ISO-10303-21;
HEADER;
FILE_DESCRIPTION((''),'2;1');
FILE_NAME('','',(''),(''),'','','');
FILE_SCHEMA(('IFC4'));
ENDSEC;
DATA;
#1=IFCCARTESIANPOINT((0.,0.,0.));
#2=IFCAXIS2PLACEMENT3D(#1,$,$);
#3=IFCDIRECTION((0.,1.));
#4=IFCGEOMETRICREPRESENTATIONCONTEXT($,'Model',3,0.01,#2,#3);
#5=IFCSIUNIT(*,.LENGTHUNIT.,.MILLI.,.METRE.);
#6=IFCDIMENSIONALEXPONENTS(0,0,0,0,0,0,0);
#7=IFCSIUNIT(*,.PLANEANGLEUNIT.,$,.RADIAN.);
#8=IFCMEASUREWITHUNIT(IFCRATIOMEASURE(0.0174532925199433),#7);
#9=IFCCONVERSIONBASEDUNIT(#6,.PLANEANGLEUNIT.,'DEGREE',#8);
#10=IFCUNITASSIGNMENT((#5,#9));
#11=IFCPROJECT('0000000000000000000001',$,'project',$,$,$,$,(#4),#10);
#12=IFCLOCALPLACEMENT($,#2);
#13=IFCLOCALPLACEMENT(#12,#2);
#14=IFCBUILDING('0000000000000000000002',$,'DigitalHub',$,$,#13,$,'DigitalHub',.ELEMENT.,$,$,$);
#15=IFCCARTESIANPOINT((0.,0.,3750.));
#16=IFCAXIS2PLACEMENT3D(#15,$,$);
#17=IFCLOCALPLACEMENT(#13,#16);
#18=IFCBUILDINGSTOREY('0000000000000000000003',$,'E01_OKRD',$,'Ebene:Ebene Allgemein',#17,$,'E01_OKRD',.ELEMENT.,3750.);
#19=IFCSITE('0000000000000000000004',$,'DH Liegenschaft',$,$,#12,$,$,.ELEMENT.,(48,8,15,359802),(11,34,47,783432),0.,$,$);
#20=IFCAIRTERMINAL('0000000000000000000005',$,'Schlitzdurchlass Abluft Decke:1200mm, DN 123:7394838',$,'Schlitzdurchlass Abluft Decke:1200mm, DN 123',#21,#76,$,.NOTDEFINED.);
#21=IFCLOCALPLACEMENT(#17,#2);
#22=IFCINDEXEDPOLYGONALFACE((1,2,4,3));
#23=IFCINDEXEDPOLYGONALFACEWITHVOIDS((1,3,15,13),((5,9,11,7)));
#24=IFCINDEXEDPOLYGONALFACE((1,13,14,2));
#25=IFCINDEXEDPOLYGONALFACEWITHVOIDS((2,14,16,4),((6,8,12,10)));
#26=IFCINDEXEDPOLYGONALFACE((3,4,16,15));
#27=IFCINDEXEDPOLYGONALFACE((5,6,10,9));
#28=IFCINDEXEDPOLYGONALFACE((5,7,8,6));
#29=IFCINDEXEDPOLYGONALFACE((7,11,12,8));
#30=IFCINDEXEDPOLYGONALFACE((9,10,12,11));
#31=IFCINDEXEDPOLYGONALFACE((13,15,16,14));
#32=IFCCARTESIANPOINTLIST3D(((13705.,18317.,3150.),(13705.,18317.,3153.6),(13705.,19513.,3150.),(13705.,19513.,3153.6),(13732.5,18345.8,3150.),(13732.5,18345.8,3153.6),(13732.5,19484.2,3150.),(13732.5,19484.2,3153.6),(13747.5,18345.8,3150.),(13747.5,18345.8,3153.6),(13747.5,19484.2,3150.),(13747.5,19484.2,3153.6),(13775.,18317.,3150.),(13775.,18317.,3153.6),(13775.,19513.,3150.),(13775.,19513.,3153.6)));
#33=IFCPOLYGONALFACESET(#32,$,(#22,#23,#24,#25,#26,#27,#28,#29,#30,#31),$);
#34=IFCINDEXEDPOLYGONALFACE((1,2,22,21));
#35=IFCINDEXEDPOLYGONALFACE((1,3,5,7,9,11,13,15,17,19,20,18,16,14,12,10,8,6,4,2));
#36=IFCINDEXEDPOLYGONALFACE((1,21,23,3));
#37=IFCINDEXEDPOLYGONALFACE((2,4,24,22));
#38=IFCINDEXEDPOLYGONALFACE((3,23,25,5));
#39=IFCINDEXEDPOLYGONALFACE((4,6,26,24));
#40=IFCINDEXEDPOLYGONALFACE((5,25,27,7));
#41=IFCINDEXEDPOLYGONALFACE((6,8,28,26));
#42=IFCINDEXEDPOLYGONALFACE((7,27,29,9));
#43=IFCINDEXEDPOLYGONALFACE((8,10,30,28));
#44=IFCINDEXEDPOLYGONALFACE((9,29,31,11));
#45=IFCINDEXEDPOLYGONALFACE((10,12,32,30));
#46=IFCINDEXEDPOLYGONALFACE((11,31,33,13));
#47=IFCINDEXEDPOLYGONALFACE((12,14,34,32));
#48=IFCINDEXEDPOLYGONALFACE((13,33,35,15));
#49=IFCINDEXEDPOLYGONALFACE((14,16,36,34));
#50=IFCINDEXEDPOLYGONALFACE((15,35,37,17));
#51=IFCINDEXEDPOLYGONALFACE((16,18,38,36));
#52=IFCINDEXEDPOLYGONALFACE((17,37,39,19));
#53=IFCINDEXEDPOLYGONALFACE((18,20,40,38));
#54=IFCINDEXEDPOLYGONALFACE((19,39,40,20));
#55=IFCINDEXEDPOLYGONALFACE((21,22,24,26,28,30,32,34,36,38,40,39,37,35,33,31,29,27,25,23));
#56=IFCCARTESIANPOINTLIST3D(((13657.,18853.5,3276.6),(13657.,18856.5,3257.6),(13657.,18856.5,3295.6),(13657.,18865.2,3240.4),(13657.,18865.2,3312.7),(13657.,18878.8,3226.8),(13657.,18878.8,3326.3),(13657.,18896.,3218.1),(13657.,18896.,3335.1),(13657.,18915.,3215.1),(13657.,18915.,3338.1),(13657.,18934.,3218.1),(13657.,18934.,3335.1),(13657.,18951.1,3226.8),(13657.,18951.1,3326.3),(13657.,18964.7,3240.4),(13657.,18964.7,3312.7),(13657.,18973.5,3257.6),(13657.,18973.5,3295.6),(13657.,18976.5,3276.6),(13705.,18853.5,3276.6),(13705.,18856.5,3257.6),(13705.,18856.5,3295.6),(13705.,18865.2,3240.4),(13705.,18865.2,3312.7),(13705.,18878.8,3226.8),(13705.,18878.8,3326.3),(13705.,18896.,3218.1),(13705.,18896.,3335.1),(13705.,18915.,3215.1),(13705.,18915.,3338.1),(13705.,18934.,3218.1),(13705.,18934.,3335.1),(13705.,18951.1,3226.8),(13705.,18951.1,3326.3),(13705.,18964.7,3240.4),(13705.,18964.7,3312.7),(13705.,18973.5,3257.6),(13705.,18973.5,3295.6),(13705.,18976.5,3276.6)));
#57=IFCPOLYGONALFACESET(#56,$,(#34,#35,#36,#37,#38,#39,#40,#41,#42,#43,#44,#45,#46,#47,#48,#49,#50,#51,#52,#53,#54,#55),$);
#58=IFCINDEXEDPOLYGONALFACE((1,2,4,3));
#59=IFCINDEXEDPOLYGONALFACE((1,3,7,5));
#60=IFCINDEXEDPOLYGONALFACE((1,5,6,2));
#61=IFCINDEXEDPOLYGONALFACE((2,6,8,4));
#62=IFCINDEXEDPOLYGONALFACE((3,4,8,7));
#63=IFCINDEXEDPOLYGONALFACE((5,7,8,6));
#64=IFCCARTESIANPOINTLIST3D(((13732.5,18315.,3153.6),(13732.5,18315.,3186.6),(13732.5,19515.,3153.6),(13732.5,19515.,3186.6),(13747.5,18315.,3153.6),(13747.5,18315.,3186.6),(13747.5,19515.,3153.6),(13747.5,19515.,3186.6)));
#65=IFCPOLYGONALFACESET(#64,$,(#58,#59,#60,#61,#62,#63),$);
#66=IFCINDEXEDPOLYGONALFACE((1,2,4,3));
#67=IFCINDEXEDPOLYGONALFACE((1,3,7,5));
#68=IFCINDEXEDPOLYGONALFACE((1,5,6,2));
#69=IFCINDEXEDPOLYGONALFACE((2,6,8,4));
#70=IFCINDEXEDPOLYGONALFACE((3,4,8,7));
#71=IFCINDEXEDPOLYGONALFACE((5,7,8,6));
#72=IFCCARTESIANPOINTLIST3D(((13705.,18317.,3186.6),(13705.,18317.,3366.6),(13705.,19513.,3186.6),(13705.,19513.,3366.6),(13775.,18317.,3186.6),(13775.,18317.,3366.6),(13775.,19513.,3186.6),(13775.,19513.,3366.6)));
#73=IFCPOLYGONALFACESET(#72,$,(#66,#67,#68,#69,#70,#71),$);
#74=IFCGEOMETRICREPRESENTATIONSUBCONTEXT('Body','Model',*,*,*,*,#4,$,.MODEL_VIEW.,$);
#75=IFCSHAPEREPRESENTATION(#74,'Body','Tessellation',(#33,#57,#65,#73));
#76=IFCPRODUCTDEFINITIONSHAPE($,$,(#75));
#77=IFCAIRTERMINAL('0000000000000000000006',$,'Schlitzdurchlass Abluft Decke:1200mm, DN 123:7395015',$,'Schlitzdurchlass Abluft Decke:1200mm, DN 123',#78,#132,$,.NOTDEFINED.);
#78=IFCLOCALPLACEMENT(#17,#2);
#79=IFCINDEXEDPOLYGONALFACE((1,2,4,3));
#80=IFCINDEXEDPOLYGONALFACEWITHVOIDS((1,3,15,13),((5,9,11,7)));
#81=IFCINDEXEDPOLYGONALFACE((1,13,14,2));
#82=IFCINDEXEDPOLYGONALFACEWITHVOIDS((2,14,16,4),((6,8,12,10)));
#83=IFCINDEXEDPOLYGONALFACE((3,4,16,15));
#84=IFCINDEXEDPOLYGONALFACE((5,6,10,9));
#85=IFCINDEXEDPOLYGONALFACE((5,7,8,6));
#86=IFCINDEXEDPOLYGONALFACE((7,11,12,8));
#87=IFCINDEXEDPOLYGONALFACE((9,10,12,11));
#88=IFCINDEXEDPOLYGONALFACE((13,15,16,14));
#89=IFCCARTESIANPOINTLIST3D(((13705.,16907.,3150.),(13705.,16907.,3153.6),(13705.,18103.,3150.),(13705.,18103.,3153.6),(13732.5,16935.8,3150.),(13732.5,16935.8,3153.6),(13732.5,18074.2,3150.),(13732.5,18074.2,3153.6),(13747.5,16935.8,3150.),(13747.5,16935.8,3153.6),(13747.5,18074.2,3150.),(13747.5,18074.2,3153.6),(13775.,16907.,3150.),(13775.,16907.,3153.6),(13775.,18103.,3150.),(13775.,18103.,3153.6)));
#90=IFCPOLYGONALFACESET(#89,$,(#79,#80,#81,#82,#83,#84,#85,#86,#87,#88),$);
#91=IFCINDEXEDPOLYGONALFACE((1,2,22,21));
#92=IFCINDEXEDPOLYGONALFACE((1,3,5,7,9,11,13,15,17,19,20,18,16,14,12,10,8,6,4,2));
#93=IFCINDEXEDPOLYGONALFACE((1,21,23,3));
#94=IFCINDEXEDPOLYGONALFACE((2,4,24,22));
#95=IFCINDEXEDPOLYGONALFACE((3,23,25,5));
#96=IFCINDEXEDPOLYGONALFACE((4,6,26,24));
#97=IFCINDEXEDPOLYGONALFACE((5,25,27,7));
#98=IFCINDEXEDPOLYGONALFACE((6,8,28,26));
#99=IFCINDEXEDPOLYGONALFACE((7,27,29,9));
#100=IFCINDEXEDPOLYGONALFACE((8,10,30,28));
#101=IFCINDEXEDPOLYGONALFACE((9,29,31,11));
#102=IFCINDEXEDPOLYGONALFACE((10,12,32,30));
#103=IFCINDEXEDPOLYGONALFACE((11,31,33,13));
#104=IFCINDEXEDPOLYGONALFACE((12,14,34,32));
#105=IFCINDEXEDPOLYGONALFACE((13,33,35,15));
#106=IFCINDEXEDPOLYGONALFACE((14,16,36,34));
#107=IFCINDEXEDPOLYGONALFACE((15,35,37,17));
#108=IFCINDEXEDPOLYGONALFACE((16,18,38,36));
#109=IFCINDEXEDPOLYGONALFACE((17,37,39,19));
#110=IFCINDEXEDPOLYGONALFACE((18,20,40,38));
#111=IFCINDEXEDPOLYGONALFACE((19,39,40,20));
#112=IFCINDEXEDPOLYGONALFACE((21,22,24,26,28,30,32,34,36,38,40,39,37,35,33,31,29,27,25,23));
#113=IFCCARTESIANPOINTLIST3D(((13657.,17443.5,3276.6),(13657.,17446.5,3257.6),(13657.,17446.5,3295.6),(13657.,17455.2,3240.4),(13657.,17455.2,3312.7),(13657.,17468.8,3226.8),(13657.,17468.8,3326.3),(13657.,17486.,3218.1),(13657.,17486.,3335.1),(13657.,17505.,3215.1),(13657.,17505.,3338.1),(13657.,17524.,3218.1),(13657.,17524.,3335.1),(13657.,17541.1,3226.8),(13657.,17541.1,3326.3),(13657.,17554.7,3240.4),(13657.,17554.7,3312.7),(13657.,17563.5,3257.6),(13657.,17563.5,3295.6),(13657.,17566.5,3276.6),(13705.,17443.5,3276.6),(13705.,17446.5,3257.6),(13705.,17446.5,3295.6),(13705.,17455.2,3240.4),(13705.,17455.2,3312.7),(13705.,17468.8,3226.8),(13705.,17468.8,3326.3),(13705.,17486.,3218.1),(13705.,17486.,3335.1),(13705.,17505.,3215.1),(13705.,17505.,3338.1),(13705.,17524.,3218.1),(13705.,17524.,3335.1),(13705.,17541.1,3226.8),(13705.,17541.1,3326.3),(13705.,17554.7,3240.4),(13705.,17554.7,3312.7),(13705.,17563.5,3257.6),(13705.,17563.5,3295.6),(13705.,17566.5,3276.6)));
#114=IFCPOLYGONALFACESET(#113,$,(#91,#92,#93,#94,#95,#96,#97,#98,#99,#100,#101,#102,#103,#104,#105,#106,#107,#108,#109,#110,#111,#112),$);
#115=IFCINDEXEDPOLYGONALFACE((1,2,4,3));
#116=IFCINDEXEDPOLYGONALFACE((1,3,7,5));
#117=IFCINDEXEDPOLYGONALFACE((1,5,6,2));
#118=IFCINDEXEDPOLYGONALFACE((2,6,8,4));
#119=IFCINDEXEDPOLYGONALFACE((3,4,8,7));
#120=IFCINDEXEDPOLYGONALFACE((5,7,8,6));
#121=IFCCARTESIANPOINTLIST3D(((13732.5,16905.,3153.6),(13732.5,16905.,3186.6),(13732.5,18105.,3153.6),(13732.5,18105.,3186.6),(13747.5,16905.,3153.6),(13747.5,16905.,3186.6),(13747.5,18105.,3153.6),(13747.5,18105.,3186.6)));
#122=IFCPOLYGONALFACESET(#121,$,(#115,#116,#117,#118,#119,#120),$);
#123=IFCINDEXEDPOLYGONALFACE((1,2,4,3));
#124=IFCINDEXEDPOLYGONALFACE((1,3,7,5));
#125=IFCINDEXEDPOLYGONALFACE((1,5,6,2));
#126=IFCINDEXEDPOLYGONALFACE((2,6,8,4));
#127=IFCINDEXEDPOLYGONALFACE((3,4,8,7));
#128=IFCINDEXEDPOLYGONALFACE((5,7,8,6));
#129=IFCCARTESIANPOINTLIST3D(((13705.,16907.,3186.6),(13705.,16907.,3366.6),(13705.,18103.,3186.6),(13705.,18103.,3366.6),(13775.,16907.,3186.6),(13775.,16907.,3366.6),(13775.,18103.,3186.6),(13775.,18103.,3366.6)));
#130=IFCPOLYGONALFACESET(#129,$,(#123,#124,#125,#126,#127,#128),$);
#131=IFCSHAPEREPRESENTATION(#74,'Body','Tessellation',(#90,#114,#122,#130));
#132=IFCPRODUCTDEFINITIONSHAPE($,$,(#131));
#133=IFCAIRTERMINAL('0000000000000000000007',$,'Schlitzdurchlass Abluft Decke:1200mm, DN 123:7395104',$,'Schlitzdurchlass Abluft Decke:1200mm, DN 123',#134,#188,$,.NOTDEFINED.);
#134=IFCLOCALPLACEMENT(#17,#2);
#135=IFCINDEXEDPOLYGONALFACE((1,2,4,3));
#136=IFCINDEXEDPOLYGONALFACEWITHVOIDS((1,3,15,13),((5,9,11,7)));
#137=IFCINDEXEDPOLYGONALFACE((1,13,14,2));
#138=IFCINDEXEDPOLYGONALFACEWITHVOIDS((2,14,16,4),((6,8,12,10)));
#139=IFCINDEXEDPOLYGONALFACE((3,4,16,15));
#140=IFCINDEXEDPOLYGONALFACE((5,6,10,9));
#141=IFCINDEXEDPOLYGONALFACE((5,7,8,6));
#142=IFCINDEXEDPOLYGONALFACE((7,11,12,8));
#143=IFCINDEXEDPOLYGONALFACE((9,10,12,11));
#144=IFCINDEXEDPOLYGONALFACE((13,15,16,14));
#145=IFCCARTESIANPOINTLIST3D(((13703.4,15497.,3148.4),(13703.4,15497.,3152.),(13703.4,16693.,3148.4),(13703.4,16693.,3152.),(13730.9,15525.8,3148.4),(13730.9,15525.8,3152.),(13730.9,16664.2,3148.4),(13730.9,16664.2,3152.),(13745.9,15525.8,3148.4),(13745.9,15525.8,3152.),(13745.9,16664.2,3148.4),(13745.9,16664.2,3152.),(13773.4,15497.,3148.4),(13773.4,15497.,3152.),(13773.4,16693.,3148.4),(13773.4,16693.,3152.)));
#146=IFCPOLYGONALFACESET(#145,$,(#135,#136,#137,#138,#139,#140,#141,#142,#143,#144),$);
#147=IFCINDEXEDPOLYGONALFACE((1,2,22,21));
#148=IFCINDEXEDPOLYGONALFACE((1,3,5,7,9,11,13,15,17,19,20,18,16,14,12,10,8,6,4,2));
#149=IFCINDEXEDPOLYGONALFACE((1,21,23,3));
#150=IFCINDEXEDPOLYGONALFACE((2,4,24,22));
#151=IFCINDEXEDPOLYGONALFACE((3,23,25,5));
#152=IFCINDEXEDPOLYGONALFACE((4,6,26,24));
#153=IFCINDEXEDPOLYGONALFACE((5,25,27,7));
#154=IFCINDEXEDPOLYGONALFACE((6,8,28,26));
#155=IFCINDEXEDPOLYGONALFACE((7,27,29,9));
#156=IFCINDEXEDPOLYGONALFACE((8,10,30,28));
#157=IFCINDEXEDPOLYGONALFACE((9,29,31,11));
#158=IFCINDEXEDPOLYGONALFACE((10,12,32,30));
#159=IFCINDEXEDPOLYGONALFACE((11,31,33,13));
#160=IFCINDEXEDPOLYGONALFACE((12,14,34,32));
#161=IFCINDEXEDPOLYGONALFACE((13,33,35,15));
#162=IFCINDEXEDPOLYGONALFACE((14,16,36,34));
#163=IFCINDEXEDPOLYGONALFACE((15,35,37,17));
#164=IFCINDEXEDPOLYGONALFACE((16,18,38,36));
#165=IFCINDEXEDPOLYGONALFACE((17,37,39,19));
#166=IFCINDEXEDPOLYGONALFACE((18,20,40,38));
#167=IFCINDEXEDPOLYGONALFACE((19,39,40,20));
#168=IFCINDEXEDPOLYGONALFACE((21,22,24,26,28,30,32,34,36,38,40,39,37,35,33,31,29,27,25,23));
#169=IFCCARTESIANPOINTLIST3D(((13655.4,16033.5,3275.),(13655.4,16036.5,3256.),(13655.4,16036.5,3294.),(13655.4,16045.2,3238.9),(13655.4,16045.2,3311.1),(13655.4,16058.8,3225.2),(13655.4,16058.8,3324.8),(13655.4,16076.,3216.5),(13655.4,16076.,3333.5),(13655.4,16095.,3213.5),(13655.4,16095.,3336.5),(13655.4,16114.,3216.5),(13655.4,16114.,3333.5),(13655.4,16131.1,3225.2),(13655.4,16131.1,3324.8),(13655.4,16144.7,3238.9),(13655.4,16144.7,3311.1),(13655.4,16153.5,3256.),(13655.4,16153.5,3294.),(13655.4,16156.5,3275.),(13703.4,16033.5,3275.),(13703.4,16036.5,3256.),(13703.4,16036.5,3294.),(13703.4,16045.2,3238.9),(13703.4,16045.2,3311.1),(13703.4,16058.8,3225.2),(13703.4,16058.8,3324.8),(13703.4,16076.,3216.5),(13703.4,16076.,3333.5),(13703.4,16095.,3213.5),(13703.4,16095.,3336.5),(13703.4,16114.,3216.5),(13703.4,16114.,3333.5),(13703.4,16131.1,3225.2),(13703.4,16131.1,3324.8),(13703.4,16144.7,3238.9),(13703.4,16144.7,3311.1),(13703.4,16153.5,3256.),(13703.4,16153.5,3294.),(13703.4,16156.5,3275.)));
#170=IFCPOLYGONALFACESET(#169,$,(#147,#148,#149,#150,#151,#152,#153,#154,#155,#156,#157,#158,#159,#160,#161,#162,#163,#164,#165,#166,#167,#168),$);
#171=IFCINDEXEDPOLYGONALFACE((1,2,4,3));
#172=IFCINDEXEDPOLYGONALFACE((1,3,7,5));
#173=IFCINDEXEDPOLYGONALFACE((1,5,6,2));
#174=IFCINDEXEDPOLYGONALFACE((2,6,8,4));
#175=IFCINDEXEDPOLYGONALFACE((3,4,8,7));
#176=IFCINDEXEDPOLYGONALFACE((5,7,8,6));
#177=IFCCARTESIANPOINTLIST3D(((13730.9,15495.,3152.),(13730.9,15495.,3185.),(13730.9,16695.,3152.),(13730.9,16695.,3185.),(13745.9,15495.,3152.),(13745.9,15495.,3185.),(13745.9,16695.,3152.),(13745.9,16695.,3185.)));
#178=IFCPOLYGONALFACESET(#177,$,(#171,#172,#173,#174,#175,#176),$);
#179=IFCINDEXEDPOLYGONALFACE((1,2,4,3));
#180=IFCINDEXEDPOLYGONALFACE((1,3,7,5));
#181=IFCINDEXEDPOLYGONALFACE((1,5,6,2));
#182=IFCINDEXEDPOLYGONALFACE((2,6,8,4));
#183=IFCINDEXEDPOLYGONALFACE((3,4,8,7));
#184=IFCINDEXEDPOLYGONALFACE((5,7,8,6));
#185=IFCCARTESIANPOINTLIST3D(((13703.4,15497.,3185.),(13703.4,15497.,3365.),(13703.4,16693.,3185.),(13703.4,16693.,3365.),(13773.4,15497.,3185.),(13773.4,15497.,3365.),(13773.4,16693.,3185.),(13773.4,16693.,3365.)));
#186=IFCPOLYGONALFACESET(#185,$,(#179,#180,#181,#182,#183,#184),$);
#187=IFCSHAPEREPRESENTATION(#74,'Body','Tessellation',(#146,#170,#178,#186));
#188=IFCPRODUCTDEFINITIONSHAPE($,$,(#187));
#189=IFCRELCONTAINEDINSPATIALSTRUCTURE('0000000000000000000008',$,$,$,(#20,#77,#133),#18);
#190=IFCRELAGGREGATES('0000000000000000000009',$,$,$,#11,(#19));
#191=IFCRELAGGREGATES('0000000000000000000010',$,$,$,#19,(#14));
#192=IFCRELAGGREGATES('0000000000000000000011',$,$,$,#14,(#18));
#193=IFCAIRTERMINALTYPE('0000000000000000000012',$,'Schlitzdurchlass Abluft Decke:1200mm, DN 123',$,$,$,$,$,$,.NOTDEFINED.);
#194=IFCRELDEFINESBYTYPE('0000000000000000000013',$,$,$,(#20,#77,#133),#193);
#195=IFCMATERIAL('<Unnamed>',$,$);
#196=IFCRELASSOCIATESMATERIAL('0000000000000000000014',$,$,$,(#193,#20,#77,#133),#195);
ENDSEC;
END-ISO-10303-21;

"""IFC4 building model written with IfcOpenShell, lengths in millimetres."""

from ifc_helpers import new_model, entity, si_unit, converted_unit, direction, frame, origin, place, context, subcontext, project, spatial, indexed_curve, outline, extrude, source, transform, mapped, material, type_object, type_shapes, element, save


model = new_model("IFC4")

# Units and contexts
model_context = context("Model", 3, precision=0.01, world=origin(), true_north=direction((0.0, 1.0)))
body_context = subcontext(model_context, "Body", "Model", "MODEL_VIEW")
ifc_project = project(units=[si_unit("LENGTHUNIT", "METRE", prefix="MILLI"), converted_unit("PLANEANGLEUNIT", "DEGREE", entity("IfcRatioMeasure", 0.0174532925199433), si_unit("PLANEANGLEUNIT", "RADIAN"), dimensions=[0, 0, 0, 0, 0, 0, 0])], contexts=[model_context])

# Site, building, storey
site_placement = place(None, origin())
site = spatial("IfcSite", under=ifc_project, at=site_placement, Name="DH Liegenschaft", CompositionType="ELEMENT", RefLatitude=(48, 8, 15, 359802), RefLongitude=(11, 34, 47, 783432), RefElevation=0.0)
building_placement = place(site_placement, origin())
building = spatial("IfcBuilding", under=site, at=building_placement, Name="DigitalHub", LongName="DigitalHub", CompositionType="ELEMENT")
storey_placement = place(building_placement, frame((0.0, 0.0, 3750.0)))
storey = spatial("IfcBuildingStorey", under=building, at=storey_placement, Name="E01_OKRD", ObjectType="Ebene:Ebene Allgemein", LongName="E01_OKRD", CompositionType="ELEMENT", Elevation=3750.0)

# Shared definitions
ifc_material_1 = material(Name="<Unnamed>")

# Air terminals
air_terminal_type_1 = type_object("IfcAirTerminalType", Name="Schlitzdurchlass Abluft Decke:1200mm, DN 123", PredefinedType="NOTDEFINED", material=ifc_material_1)
shared_shape_1 = source(origin(), body_context, "Body", "SweptSolid", [
    extrude(outline(indexed_curve([(-598.0, -35.0), (598.0, -35.0), (598.0, 35.0), (-598.0, 35.0), (-598.0, -35.0)], self_intersect=False), holes=[indexed_curve([(-569.2, -7.5), (-569.2, 7.5), (569.2, 7.5), (569.2, -7.5), (-569.2, -7.5)], self_intersect=False)]), frame((0.0, 0.0, 0.0), z_axis=(0.0, 0.0, 1.0), x_axis=(-1.0, 0.0, 0.0)), (0.0, 0.0, 1.0), 3.6),
    extrude(outline(indexed_curve([(61.5, 0.0), (58.5, 19.0), (49.8, 36.1), (36.1, 49.8), (19.0, 58.5), (0.0, 61.5), (-19.0, 58.5), (-36.1, 49.8), (-49.8, 36.1), (-58.5, 19.0), (-61.5, 0.0), (-58.5, -19.0), (-49.8, -36.1), (-36.1, -49.8), (-19.0, -58.5), (0.0, -61.5), (19.0, -58.5), (36.1, -49.8), (49.8, -36.1), (58.5, -19.0), (61.5, 0.0)], self_intersect=False)), frame((0.0, 35.0, 126.6), z_axis=(0.0, 1.0, 0.0), x_axis=(-1.0, 0.0, 0.0)), (0.0, 0.0, 1.0), 48.0),
    extrude(outline(indexed_curve([(-600.0, -7.5), (600.0, -7.5), (600.0, 7.5), (-600.0, 7.5), (-600.0, -7.5)], self_intersect=False)), frame((0.0, 0.0, 3.6), z_axis=(0.0, 0.0, 1.0), x_axis=(-1.0, 0.0, 0.0)), (0.0, 0.0, 1.0), 33.0),
    extrude(outline(indexed_curve([(-598.0, -35.0), (598.0, -35.0), (598.0, 35.0), (-598.0, 35.0), (-598.0, -35.0)], self_intersect=False)), frame((0.0, 0.0, 36.6), z_axis=(0.0, 0.0, 1.0), x_axis=(-1.0, 0.0, 0.0)), (0.0, 0.0, 1.0), 180.0),
])
type_shapes(air_terminal_type_1, [shared_shape_1])
for number, where, z_axis, x_axis, name in (
    (1, (13740.0, 18915.0, 3150.0), (0.0, 0.0, 1.0), (0.0, 1.0, 0.0), "Schlitzdurchlass Abluft Decke:1200mm, DN 123:7394838"),
    (2, (13740.0, 17505.0, 3150.0), (0.0, 0.0, 1.0), (0.0, 1.0, 0.0), "Schlitzdurchlass Abluft Decke:1200mm, DN 123:7395015"),
    (3, (13738.4, 16095.0, 3148.4), (0.0, 0.0, 1.0), (0.0, 1.0, 0.0), "Schlitzdurchlass Abluft Decke:1200mm, DN 123:7395104"),
):
    element("IfcAirTerminal", number, at=place(storey_placement, frame(where, z_axis=z_axis, x_axis=x_axis)), inside=storey, type_object=air_terminal_type_1, material=ifc_material_1, Name=name, ObjectType="Schlitzdurchlass Abluft Decke:1200mm, DN 123", PredefinedType="NOTDEFINED", context=body_context, shape_type="MappedRepresentation", body=[
        mapped(shared_shape_1, transform((0.0, 0.0, 0.0), scale=1.0)),
    ])

save(model, "model.ifc")
